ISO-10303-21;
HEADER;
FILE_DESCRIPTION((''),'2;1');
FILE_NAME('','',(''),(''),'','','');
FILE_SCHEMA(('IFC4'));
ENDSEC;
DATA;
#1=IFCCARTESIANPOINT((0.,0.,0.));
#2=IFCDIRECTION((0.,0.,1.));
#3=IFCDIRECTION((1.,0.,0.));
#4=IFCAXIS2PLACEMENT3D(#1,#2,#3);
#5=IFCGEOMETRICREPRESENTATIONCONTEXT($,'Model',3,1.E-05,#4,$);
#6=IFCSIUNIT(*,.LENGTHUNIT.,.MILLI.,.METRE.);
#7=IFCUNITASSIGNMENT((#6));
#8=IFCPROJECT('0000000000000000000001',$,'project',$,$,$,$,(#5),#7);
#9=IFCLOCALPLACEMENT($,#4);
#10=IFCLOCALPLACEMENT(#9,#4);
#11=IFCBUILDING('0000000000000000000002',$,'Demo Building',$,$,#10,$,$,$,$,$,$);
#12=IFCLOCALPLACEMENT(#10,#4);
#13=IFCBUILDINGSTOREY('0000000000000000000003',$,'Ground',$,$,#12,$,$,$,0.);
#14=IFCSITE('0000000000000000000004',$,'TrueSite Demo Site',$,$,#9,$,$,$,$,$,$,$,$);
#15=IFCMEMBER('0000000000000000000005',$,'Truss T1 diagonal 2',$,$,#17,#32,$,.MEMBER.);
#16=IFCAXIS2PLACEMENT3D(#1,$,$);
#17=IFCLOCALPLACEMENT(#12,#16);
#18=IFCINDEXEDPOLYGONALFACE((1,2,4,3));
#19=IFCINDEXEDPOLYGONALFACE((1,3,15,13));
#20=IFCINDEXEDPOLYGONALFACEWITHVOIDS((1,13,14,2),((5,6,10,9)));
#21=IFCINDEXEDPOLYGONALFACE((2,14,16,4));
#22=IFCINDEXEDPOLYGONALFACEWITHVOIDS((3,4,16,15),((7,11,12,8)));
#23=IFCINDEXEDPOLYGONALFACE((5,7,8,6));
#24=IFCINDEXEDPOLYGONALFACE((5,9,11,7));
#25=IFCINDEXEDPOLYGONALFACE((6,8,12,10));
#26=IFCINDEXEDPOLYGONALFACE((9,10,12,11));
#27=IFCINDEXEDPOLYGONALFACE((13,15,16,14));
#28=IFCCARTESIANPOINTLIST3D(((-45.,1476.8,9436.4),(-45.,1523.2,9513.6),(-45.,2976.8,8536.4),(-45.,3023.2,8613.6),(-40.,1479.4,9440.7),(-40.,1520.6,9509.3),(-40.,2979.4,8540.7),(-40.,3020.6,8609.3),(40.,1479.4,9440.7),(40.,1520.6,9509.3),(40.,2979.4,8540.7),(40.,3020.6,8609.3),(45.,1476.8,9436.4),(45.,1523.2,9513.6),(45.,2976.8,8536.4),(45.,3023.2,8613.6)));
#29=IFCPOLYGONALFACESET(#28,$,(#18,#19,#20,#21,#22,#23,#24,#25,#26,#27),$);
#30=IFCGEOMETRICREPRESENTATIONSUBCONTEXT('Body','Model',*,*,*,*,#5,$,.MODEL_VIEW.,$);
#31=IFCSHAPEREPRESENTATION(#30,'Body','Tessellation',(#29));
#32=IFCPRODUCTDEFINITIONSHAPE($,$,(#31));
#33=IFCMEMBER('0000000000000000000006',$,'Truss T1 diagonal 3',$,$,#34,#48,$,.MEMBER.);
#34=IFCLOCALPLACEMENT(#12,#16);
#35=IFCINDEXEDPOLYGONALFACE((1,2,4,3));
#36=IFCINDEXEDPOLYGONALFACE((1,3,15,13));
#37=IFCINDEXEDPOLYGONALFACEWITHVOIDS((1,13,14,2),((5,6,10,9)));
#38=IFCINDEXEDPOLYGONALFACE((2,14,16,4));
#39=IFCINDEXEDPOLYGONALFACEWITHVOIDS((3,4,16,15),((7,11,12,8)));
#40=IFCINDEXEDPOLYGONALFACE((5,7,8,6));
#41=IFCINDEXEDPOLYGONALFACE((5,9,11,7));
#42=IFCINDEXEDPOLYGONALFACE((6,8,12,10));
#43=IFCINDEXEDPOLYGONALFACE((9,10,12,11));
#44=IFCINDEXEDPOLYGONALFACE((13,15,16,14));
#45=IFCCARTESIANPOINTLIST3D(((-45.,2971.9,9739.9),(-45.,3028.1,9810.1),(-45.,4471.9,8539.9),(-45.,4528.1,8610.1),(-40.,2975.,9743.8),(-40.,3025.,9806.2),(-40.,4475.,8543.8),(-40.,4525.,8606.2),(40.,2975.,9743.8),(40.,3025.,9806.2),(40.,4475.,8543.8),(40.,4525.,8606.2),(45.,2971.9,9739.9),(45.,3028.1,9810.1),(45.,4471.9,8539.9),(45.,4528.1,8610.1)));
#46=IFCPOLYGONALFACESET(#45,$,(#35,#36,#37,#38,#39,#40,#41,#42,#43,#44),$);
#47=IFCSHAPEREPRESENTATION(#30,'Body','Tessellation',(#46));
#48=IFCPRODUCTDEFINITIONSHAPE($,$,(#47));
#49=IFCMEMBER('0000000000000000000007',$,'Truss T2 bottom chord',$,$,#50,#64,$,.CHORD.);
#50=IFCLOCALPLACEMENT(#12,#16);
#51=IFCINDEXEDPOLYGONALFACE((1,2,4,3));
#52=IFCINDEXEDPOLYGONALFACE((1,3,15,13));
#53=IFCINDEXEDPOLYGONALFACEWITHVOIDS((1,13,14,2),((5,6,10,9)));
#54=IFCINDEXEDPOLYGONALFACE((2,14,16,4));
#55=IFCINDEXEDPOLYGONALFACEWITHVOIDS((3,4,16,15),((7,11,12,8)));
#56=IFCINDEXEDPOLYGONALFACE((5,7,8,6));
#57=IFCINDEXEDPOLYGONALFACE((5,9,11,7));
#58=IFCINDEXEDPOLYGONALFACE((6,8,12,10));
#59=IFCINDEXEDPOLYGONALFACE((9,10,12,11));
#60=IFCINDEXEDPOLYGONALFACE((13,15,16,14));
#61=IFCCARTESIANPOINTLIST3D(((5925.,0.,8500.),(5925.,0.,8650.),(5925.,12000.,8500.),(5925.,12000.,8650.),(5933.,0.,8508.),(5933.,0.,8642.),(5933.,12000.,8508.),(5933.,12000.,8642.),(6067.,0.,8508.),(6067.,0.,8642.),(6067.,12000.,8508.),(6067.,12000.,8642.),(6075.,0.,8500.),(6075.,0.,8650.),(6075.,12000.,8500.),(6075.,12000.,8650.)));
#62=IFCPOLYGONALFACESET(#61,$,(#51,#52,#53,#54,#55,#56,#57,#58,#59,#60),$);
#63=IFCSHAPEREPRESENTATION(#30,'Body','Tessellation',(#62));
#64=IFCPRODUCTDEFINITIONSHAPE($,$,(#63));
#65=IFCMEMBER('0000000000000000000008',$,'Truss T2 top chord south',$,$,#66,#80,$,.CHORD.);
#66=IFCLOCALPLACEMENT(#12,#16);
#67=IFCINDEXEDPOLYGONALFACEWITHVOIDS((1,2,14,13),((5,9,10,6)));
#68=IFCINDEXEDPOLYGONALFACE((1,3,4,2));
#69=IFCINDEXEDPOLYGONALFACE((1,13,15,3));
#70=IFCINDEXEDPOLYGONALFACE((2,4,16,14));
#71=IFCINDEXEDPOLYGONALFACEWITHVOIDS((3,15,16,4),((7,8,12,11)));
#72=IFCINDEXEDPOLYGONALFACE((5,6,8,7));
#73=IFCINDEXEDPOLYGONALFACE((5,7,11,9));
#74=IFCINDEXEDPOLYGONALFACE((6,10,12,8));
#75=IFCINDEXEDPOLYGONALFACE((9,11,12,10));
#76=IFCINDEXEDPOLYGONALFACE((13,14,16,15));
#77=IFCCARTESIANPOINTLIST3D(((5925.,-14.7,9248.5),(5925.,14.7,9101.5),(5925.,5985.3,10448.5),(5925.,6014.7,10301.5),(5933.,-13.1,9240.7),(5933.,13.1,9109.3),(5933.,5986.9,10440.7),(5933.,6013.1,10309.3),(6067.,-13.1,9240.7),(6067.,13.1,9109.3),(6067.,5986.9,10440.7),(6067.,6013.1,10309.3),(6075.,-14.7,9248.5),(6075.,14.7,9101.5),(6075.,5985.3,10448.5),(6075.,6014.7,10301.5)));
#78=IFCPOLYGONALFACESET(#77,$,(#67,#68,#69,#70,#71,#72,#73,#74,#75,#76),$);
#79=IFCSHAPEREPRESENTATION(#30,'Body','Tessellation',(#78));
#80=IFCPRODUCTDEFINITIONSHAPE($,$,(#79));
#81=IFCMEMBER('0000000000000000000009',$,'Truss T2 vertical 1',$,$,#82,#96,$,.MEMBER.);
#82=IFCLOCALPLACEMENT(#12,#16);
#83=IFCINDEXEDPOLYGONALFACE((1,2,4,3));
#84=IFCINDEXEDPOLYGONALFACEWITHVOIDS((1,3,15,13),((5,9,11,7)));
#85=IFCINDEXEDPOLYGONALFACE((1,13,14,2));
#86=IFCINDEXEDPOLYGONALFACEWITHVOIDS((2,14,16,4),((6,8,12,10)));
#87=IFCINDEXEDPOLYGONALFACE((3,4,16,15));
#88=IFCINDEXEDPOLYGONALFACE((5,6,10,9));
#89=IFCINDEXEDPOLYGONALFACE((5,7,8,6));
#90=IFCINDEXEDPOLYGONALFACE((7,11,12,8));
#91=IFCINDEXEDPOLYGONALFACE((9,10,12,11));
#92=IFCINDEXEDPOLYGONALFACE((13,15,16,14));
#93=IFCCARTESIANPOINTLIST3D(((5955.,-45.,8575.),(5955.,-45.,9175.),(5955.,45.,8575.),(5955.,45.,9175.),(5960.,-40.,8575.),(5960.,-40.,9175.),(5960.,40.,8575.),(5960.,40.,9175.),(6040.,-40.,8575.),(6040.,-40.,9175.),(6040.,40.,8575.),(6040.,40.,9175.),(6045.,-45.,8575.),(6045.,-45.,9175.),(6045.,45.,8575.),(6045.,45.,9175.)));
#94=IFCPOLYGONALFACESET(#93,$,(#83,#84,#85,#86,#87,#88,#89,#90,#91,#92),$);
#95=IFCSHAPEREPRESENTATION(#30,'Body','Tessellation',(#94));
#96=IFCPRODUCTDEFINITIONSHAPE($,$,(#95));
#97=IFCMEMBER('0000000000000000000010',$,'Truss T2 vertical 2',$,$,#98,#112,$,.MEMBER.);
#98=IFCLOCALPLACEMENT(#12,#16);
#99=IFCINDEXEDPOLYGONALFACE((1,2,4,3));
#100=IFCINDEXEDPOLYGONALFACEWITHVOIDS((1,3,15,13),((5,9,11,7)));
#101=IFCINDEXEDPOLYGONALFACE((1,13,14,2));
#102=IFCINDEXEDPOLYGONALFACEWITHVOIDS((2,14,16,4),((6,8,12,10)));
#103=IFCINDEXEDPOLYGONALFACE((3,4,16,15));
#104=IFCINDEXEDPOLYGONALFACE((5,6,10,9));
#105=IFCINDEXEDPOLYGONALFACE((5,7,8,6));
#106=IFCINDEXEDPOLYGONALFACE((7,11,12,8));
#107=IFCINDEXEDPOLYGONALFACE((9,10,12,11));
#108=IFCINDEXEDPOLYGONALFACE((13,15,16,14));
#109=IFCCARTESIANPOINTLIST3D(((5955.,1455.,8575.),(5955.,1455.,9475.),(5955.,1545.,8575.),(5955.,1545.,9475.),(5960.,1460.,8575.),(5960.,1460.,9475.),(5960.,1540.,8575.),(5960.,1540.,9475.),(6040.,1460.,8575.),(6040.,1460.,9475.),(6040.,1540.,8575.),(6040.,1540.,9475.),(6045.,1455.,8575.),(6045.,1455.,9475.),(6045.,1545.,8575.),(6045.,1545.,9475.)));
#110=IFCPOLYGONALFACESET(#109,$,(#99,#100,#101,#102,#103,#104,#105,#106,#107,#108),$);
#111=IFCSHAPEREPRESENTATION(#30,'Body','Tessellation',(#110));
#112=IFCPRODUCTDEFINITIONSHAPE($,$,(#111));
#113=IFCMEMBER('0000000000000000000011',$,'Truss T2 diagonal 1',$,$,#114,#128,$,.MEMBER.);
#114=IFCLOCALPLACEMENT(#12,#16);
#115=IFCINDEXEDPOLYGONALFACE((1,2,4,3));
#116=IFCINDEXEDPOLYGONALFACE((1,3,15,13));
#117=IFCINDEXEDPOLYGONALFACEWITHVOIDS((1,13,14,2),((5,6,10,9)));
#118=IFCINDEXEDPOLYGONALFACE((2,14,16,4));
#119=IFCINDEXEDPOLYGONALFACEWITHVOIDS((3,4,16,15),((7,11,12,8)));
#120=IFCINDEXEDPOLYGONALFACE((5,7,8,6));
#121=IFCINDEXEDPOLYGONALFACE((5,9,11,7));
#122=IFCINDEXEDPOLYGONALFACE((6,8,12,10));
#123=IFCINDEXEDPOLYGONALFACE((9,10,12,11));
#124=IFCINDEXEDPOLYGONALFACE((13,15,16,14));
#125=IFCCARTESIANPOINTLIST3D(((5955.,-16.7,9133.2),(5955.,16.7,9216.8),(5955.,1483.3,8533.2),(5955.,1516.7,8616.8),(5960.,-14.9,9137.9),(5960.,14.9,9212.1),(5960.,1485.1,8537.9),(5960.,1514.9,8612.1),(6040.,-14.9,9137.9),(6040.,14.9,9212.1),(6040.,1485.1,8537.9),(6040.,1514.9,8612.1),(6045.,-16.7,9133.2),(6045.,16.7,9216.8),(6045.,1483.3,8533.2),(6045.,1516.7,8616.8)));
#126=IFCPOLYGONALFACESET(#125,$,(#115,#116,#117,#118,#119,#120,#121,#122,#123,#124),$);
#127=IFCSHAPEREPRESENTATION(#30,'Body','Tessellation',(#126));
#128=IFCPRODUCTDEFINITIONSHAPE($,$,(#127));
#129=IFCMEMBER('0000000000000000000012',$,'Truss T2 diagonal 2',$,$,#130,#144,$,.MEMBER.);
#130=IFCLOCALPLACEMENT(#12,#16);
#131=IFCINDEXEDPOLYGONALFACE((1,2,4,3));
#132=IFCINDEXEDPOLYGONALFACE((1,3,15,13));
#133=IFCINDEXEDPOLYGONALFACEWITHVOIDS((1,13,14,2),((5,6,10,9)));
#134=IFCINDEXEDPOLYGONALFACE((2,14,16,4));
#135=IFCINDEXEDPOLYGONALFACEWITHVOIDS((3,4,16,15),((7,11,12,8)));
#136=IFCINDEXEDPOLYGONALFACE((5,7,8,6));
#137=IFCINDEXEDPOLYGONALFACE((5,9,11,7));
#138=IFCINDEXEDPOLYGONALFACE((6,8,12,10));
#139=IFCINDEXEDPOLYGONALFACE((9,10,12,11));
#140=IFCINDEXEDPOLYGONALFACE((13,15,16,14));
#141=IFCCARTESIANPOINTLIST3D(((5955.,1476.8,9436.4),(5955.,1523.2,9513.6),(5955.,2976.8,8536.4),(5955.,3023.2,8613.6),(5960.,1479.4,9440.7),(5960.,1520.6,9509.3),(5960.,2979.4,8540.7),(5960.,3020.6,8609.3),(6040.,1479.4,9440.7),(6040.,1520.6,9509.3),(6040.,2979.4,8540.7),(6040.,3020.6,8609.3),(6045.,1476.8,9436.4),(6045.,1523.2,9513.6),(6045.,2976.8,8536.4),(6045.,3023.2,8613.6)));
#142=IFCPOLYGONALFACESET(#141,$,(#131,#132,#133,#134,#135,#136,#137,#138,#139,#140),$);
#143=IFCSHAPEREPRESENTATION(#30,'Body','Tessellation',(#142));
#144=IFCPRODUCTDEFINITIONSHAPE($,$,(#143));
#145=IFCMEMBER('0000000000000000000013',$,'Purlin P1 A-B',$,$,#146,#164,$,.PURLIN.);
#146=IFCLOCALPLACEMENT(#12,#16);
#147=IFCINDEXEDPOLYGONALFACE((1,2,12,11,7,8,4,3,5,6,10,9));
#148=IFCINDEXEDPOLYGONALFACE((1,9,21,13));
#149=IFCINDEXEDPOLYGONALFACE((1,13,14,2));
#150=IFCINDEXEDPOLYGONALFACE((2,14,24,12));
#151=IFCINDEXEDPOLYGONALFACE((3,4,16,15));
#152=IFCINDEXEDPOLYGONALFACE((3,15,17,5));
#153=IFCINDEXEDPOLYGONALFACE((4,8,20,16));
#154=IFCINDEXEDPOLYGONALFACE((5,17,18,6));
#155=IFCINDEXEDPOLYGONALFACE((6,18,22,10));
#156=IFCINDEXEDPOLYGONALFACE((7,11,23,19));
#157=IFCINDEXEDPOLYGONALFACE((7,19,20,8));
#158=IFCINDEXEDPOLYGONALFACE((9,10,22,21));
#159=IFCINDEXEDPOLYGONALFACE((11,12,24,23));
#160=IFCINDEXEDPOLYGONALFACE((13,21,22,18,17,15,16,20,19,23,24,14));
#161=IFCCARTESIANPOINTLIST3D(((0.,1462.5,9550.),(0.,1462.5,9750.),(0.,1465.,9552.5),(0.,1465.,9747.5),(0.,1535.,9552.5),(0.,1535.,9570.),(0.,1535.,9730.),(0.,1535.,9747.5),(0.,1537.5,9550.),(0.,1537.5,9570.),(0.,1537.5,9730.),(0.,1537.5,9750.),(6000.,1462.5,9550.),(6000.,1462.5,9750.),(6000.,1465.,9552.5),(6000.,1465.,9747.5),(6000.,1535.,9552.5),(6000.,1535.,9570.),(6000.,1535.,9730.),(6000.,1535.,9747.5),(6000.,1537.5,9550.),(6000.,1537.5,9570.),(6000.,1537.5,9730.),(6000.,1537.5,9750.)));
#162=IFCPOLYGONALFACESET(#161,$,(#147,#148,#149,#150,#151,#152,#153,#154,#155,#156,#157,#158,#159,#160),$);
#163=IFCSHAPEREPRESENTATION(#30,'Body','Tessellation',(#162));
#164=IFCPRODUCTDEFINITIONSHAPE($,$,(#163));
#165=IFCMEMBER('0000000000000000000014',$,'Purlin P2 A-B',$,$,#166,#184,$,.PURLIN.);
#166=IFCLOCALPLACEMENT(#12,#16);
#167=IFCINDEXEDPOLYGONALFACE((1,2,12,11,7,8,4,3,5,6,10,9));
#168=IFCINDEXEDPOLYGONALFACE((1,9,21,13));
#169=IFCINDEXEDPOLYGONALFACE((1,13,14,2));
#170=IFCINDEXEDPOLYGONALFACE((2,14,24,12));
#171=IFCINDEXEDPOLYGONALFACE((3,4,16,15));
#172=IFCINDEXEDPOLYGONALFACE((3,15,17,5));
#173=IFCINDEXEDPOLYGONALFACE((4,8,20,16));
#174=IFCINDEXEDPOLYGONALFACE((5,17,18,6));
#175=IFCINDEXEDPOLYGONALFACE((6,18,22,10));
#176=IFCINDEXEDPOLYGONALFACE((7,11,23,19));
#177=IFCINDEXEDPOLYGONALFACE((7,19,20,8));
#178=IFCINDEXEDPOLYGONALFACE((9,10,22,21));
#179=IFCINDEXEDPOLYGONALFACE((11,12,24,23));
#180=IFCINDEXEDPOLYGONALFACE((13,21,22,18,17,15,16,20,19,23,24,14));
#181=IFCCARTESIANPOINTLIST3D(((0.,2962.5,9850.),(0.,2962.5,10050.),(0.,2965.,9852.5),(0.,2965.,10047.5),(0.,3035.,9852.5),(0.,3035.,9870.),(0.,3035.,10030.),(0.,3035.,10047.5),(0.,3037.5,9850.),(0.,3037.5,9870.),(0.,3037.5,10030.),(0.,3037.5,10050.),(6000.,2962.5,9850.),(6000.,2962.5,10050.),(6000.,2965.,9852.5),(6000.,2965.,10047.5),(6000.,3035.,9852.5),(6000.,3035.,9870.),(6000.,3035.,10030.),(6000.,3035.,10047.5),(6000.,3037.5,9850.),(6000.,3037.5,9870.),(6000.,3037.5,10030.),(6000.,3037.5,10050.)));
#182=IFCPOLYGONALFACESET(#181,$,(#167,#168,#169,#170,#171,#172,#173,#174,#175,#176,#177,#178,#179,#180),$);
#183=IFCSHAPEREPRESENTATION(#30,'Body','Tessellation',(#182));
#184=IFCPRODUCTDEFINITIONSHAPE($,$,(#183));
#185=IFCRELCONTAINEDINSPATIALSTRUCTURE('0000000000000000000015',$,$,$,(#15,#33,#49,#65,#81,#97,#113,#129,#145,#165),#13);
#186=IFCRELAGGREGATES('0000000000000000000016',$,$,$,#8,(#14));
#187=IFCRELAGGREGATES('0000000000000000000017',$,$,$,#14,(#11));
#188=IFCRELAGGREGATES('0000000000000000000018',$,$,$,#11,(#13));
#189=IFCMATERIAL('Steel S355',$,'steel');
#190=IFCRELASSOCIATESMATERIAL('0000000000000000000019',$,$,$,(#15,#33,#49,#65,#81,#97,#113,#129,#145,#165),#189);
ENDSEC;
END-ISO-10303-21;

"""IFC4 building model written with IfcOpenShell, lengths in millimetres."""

from ifc_helpers import new_model, si_unit, frame, origin_with_axes, place, context, subcontext, project, spatial, hollow_rectangle, c_section, extrude, material, element, save


model = new_model("IFC4")

# Units and contexts
model_context = context("Model", 3, precision=1e-05, world=origin_with_axes())
body_context = subcontext(model_context, "Body", "Model", "MODEL_VIEW")
ifc_project = project(units=[si_unit("LENGTHUNIT", "METRE", prefix="MILLI")], contexts=[model_context])

# Site, building, storey
site_placement = place(None, origin_with_axes())
site = spatial("IfcSite", under=ifc_project, at=site_placement, Name="TrueSite Demo Site")
building_placement = place(site_placement, origin_with_axes())
building = spatial("IfcBuilding", under=site, at=building_placement, Name="Demo Building")
storey_placement = place(building_placement, origin_with_axes())
storey = spatial("IfcBuildingStorey", under=building, at=storey_placement, Name="Ground", Elevation=0.0)

# Shared definitions
ifc_material_1 = material(Name="Steel S355", Category="steel")

# Members
member_1_placement = place(storey_placement, frame((0.0, 1500.0, 9475.0), z_axis=(0.0, 0.857493, -0.514496), x_axis=(-1.0, 0.0, 0.0)))
element("IfcMember", 1, at=member_1_placement, inside=storey, material=ifc_material_1, Name="Truss T1 diagonal 2", PredefinedType="MEMBER", context=body_context, shape_type="SweptSolid", body=[
    extrude(hollow_rectangle(XDim=90.0, YDim=90.0, WallThickness=5.0), origin_with_axes(), (0.0, 0.0, 1.0), 1749.3),
])
member_2_placement = place(storey_placement, frame((0.0, 3000.0, 9775.0), z_axis=(0.0, 0.780869, -0.624695), x_axis=(-1.0, 0.0, 0.0)))
element("IfcMember", 2, at=member_2_placement, inside=storey, material=ifc_material_1, Name="Truss T1 diagonal 3", PredefinedType="MEMBER", context=body_context, shape_type="SweptSolid", body=[
    extrude(hollow_rectangle(XDim=90.0, YDim=90.0, WallThickness=5.0), origin_with_axes(), (0.0, 0.0, 1.0), 1920.9),
])
member_3_placement = place(storey_placement, frame((6000.0, 0.0, 8575.0), z_axis=(0.0, 1.0, 0.0), x_axis=(-1.0, 0.0, 0.0)))
element("IfcMember", 3, at=member_3_placement, inside=storey, material=ifc_material_1, Name="Truss T2 bottom chord", PredefinedType="CHORD", context=body_context, shape_type="SweptSolid", body=[
    extrude(hollow_rectangle(XDim=150.0, YDim=150.0, WallThickness=8.0), origin_with_axes(), (0.0, 0.0, 1.0), 12000.0),
])
member_4_placement = place(storey_placement, frame((6000.0, 0.0, 9175.0), z_axis=(0.0, 0.980581, 0.196116), x_axis=(-1.0, 0.0, 0.0)))
element("IfcMember", 4, at=member_4_placement, inside=storey, material=ifc_material_1, Name="Truss T2 top chord south", PredefinedType="CHORD", context=body_context, shape_type="SweptSolid", body=[
    extrude(hollow_rectangle(XDim=150.0, YDim=150.0, WallThickness=8.0), origin_with_axes(), (0.0, 0.0, 1.0), 6118.8),
])
member_5_placement = place(storey_placement, frame((6000.0, 0.0, 8575.0), z_axis=(0.0, 0.0, 1.0), x_axis=(1.0, 0.0, 0.0)))
element("IfcMember", 5, at=member_5_placement, inside=storey, material=ifc_material_1, Name="Truss T2 vertical 1", PredefinedType="MEMBER", context=body_context, shape_type="SweptSolid", body=[
    extrude(hollow_rectangle(XDim=90.0, YDim=90.0, WallThickness=5.0), origin_with_axes(), (0.0, 0.0, 1.0), 600.0),
])
member_6_placement = place(storey_placement, frame((6000.0, 1500.0, 8575.0), z_axis=(0.0, 0.0, 1.0), x_axis=(1.0, 0.0, 0.0)))
element("IfcMember", 6, at=member_6_placement, inside=storey, material=ifc_material_1, Name="Truss T2 vertical 2", PredefinedType="MEMBER", context=body_context, shape_type="SweptSolid", body=[
    extrude(hollow_rectangle(XDim=90.0, YDim=90.0, WallThickness=5.0), origin_with_axes(), (0.0, 0.0, 1.0), 900.0),
])
member_7_placement = place(storey_placement, frame((6000.0, 0.0, 9175.0), z_axis=(0.0, 0.928477, -0.371391), x_axis=(-1.0, 0.0, 0.0)))
element("IfcMember", 7, at=member_7_placement, inside=storey, material=ifc_material_1, Name="Truss T2 diagonal 1", PredefinedType="MEMBER", context=body_context, shape_type="SweptSolid", body=[
    extrude(hollow_rectangle(XDim=90.0, YDim=90.0, WallThickness=5.0), origin_with_axes(), (0.0, 0.0, 1.0), 1615.5),
])
member_8_placement = place(storey_placement, frame((6000.0, 1500.0, 9475.0), z_axis=(0.0, 0.857493, -0.514496), x_axis=(-1.0, 0.0, 0.0)))
element("IfcMember", 8, at=member_8_placement, inside=storey, material=ifc_material_1, Name="Truss T2 diagonal 2", PredefinedType="MEMBER", context=body_context, shape_type="SweptSolid", body=[
    extrude(hollow_rectangle(XDim=90.0, YDim=90.0, WallThickness=5.0), origin_with_axes(), (0.0, 0.0, 1.0), 1749.3),
])
for number, where, z_axis, x_axis, name in (
    (9, (0.0, 1500.0, 9650.0), (1.0, 0.0, 0.0), (0.0, 1.0, 0.0), "Purlin P1 A-B"),
    (10, (0.0, 3000.0, 9950.0), (1.0, 0.0, 0.0), (0.0, 1.0, 0.0), "Purlin P2 A-B"),
):
    element("IfcMember", number, at=place(storey_placement, frame(where, z_axis=z_axis, x_axis=x_axis)), inside=storey, material=ifc_material_1, Name=name, PredefinedType="PURLIN", context=body_context, shape_type="SweptSolid", body=[
        extrude(c_section(Depth=200.0, Width=75.0, WallThickness=2.5, Girth=20.0), origin_with_axes(), (0.0, 0.0, 1.0), 6000.0),
    ])

save(model, "model.ifc")
